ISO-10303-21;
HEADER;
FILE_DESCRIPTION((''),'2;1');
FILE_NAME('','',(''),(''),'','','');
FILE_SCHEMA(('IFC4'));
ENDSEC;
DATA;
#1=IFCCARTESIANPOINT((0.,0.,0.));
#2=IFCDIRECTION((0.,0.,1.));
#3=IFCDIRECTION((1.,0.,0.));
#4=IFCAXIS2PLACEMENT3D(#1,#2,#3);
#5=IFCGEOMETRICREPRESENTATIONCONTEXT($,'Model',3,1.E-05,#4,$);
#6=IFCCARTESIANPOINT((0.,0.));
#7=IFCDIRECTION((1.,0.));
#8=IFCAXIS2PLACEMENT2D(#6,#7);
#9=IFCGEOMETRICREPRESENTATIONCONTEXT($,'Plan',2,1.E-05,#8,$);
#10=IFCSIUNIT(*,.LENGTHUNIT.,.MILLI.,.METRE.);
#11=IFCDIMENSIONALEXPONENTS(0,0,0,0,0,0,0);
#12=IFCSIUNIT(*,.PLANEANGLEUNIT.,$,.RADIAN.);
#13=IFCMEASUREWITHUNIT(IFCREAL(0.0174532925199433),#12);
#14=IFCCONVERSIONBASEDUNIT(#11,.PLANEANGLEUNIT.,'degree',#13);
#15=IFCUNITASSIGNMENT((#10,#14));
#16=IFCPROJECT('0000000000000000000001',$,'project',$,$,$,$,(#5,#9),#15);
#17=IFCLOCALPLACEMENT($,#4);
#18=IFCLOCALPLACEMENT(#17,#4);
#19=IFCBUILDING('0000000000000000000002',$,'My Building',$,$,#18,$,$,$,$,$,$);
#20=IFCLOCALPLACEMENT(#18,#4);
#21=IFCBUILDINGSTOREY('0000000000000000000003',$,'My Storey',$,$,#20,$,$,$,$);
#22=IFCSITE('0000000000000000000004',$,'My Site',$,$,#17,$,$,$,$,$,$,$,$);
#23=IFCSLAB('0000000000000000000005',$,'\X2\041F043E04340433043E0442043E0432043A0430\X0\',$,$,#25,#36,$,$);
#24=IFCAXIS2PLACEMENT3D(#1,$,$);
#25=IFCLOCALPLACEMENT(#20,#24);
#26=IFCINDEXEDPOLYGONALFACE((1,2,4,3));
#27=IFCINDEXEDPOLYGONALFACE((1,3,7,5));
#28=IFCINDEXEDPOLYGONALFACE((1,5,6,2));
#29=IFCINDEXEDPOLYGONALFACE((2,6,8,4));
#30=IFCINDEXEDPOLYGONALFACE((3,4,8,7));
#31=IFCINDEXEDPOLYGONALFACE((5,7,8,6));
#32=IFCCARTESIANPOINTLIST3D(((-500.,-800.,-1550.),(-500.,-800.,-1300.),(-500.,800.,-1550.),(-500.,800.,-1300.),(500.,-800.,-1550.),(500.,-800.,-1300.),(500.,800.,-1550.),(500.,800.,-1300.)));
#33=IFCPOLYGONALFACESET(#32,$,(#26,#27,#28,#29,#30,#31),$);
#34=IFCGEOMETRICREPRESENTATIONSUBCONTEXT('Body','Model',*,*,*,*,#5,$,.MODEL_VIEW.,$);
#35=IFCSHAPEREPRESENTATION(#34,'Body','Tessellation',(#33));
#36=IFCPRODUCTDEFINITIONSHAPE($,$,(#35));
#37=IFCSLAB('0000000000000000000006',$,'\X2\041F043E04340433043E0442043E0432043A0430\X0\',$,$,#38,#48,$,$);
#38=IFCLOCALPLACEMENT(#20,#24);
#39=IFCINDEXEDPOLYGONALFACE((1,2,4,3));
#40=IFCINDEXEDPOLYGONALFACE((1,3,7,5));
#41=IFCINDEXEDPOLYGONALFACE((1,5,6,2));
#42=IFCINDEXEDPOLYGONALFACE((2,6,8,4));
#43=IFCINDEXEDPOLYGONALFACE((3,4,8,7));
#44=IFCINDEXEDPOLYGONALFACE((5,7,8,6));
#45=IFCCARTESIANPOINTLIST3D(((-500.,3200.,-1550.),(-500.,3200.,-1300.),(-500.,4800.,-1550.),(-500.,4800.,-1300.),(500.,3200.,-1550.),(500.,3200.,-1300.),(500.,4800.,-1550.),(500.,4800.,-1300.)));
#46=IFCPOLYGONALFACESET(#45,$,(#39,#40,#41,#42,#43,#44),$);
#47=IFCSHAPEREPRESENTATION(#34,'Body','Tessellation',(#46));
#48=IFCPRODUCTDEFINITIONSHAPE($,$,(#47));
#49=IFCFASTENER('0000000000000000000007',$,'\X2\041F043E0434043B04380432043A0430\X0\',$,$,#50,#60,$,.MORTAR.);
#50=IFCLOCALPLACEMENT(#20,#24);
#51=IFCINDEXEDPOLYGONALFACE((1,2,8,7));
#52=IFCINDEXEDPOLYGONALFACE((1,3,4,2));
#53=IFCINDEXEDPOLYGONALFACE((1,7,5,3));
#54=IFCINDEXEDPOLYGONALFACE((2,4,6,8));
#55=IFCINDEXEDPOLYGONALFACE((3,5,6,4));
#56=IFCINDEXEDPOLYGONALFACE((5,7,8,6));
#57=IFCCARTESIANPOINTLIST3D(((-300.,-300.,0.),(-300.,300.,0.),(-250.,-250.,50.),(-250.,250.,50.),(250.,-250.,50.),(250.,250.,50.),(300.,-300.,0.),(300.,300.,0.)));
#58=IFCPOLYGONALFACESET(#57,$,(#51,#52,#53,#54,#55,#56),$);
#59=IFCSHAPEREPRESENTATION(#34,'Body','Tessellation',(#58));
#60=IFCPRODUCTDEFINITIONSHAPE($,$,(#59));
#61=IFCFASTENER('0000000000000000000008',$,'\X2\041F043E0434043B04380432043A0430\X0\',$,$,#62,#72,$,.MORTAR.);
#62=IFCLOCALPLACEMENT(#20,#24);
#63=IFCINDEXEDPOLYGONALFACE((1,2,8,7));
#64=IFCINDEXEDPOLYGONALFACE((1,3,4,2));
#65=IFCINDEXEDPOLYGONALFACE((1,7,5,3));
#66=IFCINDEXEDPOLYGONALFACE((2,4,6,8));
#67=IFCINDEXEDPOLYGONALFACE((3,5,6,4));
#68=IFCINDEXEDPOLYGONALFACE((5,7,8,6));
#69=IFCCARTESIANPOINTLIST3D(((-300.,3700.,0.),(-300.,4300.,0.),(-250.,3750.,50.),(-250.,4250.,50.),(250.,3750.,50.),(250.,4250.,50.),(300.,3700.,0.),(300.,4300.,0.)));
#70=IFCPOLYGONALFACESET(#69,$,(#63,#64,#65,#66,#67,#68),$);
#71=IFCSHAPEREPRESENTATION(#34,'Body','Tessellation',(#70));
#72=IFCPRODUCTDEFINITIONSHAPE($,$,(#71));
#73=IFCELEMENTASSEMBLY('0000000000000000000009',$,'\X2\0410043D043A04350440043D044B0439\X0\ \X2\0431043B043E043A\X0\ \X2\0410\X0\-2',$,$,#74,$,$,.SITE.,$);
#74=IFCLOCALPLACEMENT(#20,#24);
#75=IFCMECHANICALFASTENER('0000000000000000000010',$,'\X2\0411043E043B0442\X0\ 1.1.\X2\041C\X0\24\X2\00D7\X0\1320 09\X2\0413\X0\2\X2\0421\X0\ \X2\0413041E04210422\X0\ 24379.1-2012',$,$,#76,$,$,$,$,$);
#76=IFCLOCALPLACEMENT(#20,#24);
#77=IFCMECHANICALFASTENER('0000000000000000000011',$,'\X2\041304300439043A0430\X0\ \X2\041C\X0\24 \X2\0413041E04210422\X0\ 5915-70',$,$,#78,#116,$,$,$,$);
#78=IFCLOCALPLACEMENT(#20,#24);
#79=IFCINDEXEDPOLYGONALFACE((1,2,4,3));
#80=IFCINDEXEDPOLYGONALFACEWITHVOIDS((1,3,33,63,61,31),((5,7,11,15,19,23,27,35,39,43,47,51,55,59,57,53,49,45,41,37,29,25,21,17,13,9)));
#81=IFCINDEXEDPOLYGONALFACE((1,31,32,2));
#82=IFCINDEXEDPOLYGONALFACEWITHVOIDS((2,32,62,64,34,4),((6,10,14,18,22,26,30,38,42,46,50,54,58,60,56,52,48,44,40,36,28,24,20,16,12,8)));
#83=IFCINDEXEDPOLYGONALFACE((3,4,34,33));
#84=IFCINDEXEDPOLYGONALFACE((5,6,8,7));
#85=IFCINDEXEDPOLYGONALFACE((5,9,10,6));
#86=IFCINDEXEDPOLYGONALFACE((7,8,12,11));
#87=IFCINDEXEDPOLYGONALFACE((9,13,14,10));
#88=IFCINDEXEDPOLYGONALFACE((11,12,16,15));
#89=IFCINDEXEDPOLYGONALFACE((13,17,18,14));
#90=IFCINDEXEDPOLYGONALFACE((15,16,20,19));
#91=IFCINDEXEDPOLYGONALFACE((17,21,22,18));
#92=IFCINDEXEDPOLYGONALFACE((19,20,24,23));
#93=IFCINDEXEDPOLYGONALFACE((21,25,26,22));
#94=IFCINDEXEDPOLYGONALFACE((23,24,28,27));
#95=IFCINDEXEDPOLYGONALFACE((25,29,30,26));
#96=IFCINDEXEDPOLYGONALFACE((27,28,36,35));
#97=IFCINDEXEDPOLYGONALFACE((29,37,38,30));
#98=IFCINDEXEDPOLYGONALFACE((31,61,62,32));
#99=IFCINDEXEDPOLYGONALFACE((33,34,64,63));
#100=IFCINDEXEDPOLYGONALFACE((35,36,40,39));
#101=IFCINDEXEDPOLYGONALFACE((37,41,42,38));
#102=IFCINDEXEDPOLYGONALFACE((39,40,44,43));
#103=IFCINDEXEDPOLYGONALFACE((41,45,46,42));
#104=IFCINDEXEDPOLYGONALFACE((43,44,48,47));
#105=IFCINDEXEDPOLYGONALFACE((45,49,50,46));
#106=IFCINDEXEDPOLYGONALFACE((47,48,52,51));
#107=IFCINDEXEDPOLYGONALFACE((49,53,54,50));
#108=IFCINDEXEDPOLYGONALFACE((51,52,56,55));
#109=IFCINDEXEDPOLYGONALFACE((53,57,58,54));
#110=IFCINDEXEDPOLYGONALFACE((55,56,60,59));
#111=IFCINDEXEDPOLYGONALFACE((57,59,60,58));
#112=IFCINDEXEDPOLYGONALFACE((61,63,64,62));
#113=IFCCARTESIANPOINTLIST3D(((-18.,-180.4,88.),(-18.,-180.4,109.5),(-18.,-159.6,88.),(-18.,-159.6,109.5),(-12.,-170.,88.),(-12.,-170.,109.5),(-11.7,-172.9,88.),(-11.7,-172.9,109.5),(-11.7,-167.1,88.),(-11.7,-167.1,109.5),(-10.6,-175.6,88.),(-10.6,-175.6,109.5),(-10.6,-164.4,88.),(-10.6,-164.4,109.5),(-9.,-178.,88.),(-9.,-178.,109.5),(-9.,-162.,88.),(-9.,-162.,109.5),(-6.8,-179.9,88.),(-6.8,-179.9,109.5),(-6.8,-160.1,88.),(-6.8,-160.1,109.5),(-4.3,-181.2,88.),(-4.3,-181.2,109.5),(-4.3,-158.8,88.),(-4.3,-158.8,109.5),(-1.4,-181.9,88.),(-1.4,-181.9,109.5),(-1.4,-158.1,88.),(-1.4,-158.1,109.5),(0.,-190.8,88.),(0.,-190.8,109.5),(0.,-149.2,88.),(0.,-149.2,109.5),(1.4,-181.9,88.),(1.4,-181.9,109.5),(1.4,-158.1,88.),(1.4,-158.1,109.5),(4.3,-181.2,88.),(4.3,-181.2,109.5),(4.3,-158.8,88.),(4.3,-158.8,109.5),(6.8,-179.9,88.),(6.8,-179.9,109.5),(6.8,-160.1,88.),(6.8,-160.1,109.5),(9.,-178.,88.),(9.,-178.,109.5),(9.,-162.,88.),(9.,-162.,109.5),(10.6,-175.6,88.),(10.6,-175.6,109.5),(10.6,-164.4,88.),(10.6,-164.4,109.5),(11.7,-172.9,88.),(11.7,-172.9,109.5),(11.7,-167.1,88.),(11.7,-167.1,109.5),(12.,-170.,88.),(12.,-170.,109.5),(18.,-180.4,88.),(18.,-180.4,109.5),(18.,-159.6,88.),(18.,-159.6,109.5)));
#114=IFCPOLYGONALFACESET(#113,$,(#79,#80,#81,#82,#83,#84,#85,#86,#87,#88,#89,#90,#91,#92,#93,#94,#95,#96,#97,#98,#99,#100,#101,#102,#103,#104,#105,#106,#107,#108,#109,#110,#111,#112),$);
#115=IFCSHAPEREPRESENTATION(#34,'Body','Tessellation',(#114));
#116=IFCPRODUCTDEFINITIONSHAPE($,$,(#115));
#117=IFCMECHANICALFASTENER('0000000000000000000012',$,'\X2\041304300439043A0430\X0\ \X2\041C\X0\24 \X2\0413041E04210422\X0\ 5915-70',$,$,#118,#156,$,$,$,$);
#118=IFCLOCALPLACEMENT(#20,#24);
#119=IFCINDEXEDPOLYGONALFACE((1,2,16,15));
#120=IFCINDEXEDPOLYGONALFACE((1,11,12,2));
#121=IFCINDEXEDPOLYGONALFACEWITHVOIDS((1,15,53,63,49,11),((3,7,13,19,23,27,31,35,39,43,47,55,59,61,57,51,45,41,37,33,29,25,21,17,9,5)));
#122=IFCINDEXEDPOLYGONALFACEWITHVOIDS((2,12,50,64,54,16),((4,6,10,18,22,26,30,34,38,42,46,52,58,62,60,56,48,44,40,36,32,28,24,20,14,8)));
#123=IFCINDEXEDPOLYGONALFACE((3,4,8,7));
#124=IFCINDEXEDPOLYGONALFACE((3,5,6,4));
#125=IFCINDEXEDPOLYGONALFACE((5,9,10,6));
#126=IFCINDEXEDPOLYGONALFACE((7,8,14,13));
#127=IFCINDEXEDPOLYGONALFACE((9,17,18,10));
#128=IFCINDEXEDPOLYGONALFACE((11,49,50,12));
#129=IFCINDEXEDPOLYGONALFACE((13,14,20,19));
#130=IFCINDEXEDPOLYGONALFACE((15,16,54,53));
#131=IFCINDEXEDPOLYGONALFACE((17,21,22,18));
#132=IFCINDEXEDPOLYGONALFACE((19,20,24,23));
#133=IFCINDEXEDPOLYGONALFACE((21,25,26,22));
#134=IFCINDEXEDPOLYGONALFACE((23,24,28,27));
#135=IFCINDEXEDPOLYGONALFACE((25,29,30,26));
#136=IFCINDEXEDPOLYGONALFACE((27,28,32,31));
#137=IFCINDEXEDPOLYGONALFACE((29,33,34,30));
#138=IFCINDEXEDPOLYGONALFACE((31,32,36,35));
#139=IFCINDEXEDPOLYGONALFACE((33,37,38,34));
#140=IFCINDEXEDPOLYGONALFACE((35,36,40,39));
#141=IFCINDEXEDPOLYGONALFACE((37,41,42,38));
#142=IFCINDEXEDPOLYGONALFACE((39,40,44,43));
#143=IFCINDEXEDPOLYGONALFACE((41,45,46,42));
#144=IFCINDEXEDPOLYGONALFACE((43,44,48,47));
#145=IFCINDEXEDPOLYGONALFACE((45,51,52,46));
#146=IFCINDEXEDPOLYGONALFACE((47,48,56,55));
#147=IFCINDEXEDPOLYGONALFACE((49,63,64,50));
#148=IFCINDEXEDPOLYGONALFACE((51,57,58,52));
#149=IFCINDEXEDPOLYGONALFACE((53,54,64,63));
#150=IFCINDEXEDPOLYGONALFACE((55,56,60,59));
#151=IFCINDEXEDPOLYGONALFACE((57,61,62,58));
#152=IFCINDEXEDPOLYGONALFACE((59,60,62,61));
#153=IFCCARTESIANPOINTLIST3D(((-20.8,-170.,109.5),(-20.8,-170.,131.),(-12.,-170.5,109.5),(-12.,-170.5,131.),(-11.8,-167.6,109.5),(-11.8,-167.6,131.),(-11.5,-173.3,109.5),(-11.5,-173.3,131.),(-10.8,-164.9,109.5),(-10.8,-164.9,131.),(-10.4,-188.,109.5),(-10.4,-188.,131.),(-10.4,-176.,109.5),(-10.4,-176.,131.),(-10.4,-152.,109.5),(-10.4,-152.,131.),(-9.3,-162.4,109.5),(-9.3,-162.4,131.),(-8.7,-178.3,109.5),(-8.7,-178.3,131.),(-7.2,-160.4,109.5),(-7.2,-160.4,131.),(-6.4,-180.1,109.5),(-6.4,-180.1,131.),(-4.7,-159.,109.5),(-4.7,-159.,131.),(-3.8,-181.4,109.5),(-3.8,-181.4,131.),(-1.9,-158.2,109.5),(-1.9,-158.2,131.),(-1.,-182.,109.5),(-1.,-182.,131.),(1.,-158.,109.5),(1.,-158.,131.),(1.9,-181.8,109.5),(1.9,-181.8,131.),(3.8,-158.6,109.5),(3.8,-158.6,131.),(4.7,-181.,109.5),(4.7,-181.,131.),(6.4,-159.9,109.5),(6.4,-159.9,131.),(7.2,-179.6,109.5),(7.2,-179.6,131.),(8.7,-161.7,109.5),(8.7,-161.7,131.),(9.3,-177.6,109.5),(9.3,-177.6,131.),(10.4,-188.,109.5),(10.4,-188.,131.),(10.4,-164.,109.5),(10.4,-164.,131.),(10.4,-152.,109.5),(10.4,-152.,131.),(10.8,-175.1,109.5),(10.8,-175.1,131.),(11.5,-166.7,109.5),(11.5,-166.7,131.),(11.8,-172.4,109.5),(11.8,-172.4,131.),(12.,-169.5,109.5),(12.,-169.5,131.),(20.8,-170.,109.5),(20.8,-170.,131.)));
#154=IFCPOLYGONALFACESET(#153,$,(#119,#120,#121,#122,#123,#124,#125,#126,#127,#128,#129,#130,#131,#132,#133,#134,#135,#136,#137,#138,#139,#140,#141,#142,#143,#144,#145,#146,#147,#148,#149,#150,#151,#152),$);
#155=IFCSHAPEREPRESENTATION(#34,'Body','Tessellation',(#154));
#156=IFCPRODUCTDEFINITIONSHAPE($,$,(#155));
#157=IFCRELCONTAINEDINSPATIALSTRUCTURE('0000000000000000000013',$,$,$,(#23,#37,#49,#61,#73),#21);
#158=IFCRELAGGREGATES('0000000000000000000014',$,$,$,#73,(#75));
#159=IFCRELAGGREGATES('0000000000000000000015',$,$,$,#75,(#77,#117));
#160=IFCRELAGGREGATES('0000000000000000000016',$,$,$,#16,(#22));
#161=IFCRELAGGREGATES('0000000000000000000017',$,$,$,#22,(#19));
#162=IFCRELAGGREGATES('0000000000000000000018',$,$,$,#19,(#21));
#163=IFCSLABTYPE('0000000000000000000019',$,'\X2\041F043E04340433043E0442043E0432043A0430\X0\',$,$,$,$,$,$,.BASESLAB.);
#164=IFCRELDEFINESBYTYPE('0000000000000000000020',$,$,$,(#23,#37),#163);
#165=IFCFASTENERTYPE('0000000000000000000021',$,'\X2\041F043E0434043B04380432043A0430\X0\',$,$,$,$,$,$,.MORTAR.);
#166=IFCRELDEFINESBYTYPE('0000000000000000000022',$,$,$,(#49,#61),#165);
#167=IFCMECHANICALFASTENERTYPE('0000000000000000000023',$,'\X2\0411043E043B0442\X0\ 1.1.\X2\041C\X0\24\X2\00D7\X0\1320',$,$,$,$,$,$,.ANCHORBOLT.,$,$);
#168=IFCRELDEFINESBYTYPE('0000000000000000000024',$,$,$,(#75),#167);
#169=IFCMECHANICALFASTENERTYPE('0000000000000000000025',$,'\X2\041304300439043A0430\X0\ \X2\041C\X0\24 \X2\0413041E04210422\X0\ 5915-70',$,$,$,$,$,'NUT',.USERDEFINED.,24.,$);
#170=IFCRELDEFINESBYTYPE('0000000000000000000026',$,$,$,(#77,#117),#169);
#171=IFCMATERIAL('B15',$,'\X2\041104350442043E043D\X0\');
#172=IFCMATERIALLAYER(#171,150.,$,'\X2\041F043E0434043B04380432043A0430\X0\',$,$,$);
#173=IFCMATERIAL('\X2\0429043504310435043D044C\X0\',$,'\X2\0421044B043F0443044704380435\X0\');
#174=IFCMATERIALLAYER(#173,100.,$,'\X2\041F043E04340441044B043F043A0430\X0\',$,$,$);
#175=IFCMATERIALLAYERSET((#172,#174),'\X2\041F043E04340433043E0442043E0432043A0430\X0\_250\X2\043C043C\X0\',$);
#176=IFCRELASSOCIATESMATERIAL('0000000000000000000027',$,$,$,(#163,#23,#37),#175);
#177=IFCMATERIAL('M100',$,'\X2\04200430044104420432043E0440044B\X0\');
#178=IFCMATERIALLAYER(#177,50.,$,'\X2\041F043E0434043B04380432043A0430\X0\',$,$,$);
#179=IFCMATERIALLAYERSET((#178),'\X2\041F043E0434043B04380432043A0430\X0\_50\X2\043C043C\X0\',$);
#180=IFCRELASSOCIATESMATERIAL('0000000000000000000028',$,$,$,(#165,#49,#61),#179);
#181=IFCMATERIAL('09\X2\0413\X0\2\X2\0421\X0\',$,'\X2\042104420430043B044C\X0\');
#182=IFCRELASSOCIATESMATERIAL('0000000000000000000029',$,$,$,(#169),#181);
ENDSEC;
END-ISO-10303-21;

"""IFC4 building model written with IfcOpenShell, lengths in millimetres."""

from ifc_helpers import new_model, entity, si_unit, converted_unit, frame, origin_with_axes, origin_2d_with_axis, place, context, subcontext, project, spatial, polyline, line, indexed_curve, outline, extrude, clip, halfspace, source, transform, mapped, material, layer, layer_set, layer_usage, type_object, type_shapes, element, aggregate, save


model = new_model("IFC4")

# Units and contexts
model_context = context("Model", 3, precision=1e-05, world=origin_with_axes())
plan_context = context("Plan", 2, precision=1e-05, world=origin_2d_with_axis())
body_context = subcontext(model_context, "Body", "Model", "MODEL_VIEW")
ifc_project = project(units=[si_unit("LENGTHUNIT", "METRE", prefix="MILLI"), converted_unit("PLANEANGLEUNIT", "degree", entity("IfcReal", 0.0174532925199433), si_unit("PLANEANGLEUNIT", "RADIAN"), dimensions=[0, 0, 0, 0, 0, 0, 0])], contexts=[model_context, plan_context])

# Site, building, storey
site_placement = place(None, origin_with_axes())
site = spatial("IfcSite", under=ifc_project, at=site_placement, Name="My Site")
building_placement = place(site_placement, origin_with_axes())
building = spatial("IfcBuilding", under=site, at=building_placement, Name="My Building")
storey_placement = place(building_placement, origin_with_axes())
storey = spatial("IfcBuildingStorey", under=building, at=storey_placement, Name="My Storey")

# Slabs
ifc_material_1 = material(Name="B15", Category="Бетон")
ifc_layer_1 = layer(ifc_material_1, 150.0, Name="Подливка")
ifc_material_2 = material(Name="Щебень", Category="Сыпучие")
ifc_layer_2 = layer(ifc_material_2, 100.0, Name="Подсыпка")
ifc_layer_set_1 = layer_set([ifc_layer_1, ifc_layer_2], Name="Подготовка_250мм")
ifc_layer_usage_1 = layer_usage(ifc_layer_set_1, "AXIS3", "NEGATIVE", 0.0)
slab_type = type_object("IfcSlabType", Name="Подготовка", PredefinedType="BASESLAB", material=ifc_layer_set_1)
for number, where, z_axis, x_axis, name in (
    (1, (0.0, 0.0, -1550.0), (0.0, 0.0, 1.0), (1.0, 0.0, 0.0), "Подготовка"),
    (2, (0.0, 4000.0, -1550.0), (0.0, 0.0, 1.0), (1.0, 0.0, 0.0), "Подготовка"),
):
    element("IfcSlab", number, at=place(storey_placement, frame(where, z_axis=z_axis, x_axis=x_axis)), inside=storey, type_object=slab_type, material=ifc_layer_usage_1, Name=name, context=body_context, shape_type="SweptSolid", body=[
        extrude(outline(indexed_curve([(-500.0, -800.0), (500.0, -800.0), (500.0, 800.0), (-500.0, 800.0)], segments=[line(3, 2), line(2, 1), line(1, 4), line(4, 3)], self_intersect=False)), None, (0.0, 0.0, 1.0), 250.0),
    ])

# Fasteners
ifc_material_3 = material(Name="M100", Category="Растворы")
ifc_layer_3 = layer(ifc_material_3, 50.0, Name="Подливка")
ifc_layer_set_2 = layer_set([ifc_layer_3], Name="Подливка_50мм")
ifc_layer_usage_2 = layer_usage(ifc_layer_set_2, "AXIS3", "POSITIVE", 0.0)
fastener_type = type_object("IfcFastenerType", Name="Подливка", PredefinedType="MORTAR", material=ifc_layer_set_2)
placement_1 = place(storey_placement, origin_with_axes())
element("IfcFastener", 3, at=placement_1, inside=storey, type_object=fastener_type, material=ifc_layer_usage_2, Name="Подливка", PredefinedType="MORTAR", context=body_context, shape_type="Clipping", body=[
    clip(clip(clip(clip(extrude(outline(indexed_curve([(-300.0, -300.0), (300.0, -300.0), (300.0, 300.0), (-300.0, 300.0)], segments=[line(3, 2), line(2, 1), line(1, 4), line(4, 3)], self_intersect=False)), None, (0.0, 0.0, 1.0), 50.0), halfspace(frame((-53.6, 200.0, 353.6), z_axis=(0.707107, 0.0, 0.707107), x_axis=(0.707107, 0.0, -0.707107)), False)), halfspace(frame((-200.0, -53.6, 353.6), z_axis=(0.0, 0.707107, 0.707107), x_axis=(0.0, 0.707107, -0.707107)), False)), halfspace(frame((200.0, 53.6, 353.6), z_axis=(0.0, -0.707107, 0.707107), x_axis=(0.0, -0.707107, -0.707107)), False)), halfspace(frame((53.6, 200.0, 353.6), z_axis=(-0.707107, 0.0, 0.707107), x_axis=(-0.707107, 0.0, -0.707107)), False)),
])
placement_2 = place(storey_placement, frame((0.0, 4000.0, 0.0), z_axis=(0.0, 0.0, 1.0), x_axis=(1.0, 0.0, 0.0)))
element("IfcFastener", 4, at=placement_2, inside=storey, type_object=fastener_type, material=ifc_layer_usage_2, Name="Подливка", PredefinedType="MORTAR", context=body_context, shape_type="Clipping", body=[
    clip(clip(clip(clip(extrude(outline(indexed_curve([(-300.0, -300.0), (300.0, -300.0), (300.0, 300.0), (-300.0, 300.0)], segments=[line(3, 2), line(2, 1), line(1, 4), line(4, 3)], self_intersect=False)), None, (0.0, 0.0, 1.0), 50.0), halfspace(frame((-53.6, 200.0, 353.6), z_axis=(0.707107, 0.0, 0.707107), x_axis=(0.707107, 0.0, -0.707107)), False)), halfspace(frame((-200.0, -53.6, 353.6), z_axis=(0.0, 0.707107, 0.707107), x_axis=(0.0, 0.707107, -0.707107)), False)), halfspace(frame((200.0, 53.6, 353.6), z_axis=(0.0, -0.707107, 0.707107), x_axis=(0.0, -0.707107, -0.707107)), False)), halfspace(frame((53.6, 200.0, 353.6), z_axis=(-0.707107, 0.0, 0.707107), x_axis=(-0.707107, 0.0, -0.707107)), False)),
])

# Element assembly, mechanical fastener
assembly_1 = element("IfcElementAssembly", 5, at=placement_1, inside=storey, Name="Анкерный блок А-2", AssemblyPlace="SITE")
mechanical_fastener_type_1 = type_object("IfcMechanicalFastenerType", Name="Болт 1.1.М24×1320", PredefinedType="ANCHORBOLT")
mechanical_fastener_1_placement = place(placement_1, frame((0.0, -170.0, 0.0), z_axis=(0.0, 0.0, 1.0), x_axis=(1.0, 0.0, 0.0)))
mechanical_fastener_1 = element("IfcMechanicalFastener", 6, at=mechanical_fastener_1_placement, type_object=mechanical_fastener_type_1, Name="Болт 1.1.М24×1320 09Г2С ГОСТ 24379.1-2012")
ifc_material_4 = material(Name="09Г2С", Category="Сталь")
aggregate(assembly_1, [mechanical_fastener_1])

# Mechanical fasteners
mechanical_fastener_type_2 = type_object("IfcMechanicalFastenerType", Name="Гайка М24 ГОСТ 5915-70", ElementType="NUT", NominalDiameter=24.0, PredefinedType="USERDEFINED", material=ifc_material_4)
shared_shape_1 = source(origin_with_axes(), body_context, "Body", "SweptSolid", [
    extrude(outline(polyline([(-10.4, -18.0), (10.4, -18.0), (20.8, 0.0), (10.4, 18.0), (-10.4, 18.0), (-20.8, 0.0), (-10.4, -18.0)]), holes=[polyline([(-8.0, 9.0), (-5.6, 10.6), (-2.9, 11.7), (0.0, 12.0), (2.9, 11.7), (5.6, 10.6), (8.0, 9.0), (9.9, 6.8), (11.2, 4.3), (11.9, 1.4), (11.9, -1.4), (11.2, -4.3), (9.9, -6.8), (8.0, -9.0), (5.6, -10.6), (2.9, -11.7), (0.0, -12.0), (-2.9, -11.7), (-5.6, -10.6), (-8.0, -9.0), (-9.9, -6.8), (-11.2, -4.3), (-11.9, -1.4), (-11.9, 1.4), (-11.2, 4.3), (-9.9, 6.8), (-8.0, 9.0)])]), frame((0.0, 0.0, 0.0), z_axis=(0.0, 0.0, 1.0), x_axis=(0.0, 1.0, 0.0)), (0.0, 0.0, 1.0), 21.5),
])
type_shapes(mechanical_fastener_type_2, [shared_shape_1])
mechanical_fastener_2_placement = place(mechanical_fastener_1_placement, frame((0.0, 0.0, 88.0), z_axis=(0.0, 0.0, 1.0), x_axis=(1.0, 0.0, 0.0)))
mechanical_fastener_2 = element("IfcMechanicalFastener", 7, at=mechanical_fastener_2_placement, type_object=mechanical_fastener_type_2, Name="Гайка М24 ГОСТ 5915-70", context=body_context, shape_type="MappedRepresentation", body=[
    mapped(shared_shape_1, transform((0.0, 0.0, 0.0), x_axis=(1.0, 0.0, 0.0), y_axis=(0.0, 1.0, 0.0), z_axis=(0.0, 0.0, 1.0), scale=1.0)),
])
mechanical_fastener_3_placement = place(mechanical_fastener_1_placement, frame((0.0, 0.0, 109.5), z_axis=(0.0, 0.0, 1.0), x_axis=(0.866025, 0.5, 0.0)))
mechanical_fastener_3 = element("IfcMechanicalFastener", 8, at=mechanical_fastener_3_placement, type_object=mechanical_fastener_type_2, Name="Гайка М24 ГОСТ 5915-70", context=body_context, shape_type="MappedRepresentation", body=[
    mapped(shared_shape_1, transform((0.0, 0.0, 0.0), x_axis=(1.0, 0.0, 0.0), y_axis=(0.0, 1.0, 0.0), z_axis=(0.0, 0.0, 1.0), scale=1.0)),
])
aggregate(mechanical_fastener_1, [mechanical_fastener_2, mechanical_fastener_3])

save(model, "model.ifc")
